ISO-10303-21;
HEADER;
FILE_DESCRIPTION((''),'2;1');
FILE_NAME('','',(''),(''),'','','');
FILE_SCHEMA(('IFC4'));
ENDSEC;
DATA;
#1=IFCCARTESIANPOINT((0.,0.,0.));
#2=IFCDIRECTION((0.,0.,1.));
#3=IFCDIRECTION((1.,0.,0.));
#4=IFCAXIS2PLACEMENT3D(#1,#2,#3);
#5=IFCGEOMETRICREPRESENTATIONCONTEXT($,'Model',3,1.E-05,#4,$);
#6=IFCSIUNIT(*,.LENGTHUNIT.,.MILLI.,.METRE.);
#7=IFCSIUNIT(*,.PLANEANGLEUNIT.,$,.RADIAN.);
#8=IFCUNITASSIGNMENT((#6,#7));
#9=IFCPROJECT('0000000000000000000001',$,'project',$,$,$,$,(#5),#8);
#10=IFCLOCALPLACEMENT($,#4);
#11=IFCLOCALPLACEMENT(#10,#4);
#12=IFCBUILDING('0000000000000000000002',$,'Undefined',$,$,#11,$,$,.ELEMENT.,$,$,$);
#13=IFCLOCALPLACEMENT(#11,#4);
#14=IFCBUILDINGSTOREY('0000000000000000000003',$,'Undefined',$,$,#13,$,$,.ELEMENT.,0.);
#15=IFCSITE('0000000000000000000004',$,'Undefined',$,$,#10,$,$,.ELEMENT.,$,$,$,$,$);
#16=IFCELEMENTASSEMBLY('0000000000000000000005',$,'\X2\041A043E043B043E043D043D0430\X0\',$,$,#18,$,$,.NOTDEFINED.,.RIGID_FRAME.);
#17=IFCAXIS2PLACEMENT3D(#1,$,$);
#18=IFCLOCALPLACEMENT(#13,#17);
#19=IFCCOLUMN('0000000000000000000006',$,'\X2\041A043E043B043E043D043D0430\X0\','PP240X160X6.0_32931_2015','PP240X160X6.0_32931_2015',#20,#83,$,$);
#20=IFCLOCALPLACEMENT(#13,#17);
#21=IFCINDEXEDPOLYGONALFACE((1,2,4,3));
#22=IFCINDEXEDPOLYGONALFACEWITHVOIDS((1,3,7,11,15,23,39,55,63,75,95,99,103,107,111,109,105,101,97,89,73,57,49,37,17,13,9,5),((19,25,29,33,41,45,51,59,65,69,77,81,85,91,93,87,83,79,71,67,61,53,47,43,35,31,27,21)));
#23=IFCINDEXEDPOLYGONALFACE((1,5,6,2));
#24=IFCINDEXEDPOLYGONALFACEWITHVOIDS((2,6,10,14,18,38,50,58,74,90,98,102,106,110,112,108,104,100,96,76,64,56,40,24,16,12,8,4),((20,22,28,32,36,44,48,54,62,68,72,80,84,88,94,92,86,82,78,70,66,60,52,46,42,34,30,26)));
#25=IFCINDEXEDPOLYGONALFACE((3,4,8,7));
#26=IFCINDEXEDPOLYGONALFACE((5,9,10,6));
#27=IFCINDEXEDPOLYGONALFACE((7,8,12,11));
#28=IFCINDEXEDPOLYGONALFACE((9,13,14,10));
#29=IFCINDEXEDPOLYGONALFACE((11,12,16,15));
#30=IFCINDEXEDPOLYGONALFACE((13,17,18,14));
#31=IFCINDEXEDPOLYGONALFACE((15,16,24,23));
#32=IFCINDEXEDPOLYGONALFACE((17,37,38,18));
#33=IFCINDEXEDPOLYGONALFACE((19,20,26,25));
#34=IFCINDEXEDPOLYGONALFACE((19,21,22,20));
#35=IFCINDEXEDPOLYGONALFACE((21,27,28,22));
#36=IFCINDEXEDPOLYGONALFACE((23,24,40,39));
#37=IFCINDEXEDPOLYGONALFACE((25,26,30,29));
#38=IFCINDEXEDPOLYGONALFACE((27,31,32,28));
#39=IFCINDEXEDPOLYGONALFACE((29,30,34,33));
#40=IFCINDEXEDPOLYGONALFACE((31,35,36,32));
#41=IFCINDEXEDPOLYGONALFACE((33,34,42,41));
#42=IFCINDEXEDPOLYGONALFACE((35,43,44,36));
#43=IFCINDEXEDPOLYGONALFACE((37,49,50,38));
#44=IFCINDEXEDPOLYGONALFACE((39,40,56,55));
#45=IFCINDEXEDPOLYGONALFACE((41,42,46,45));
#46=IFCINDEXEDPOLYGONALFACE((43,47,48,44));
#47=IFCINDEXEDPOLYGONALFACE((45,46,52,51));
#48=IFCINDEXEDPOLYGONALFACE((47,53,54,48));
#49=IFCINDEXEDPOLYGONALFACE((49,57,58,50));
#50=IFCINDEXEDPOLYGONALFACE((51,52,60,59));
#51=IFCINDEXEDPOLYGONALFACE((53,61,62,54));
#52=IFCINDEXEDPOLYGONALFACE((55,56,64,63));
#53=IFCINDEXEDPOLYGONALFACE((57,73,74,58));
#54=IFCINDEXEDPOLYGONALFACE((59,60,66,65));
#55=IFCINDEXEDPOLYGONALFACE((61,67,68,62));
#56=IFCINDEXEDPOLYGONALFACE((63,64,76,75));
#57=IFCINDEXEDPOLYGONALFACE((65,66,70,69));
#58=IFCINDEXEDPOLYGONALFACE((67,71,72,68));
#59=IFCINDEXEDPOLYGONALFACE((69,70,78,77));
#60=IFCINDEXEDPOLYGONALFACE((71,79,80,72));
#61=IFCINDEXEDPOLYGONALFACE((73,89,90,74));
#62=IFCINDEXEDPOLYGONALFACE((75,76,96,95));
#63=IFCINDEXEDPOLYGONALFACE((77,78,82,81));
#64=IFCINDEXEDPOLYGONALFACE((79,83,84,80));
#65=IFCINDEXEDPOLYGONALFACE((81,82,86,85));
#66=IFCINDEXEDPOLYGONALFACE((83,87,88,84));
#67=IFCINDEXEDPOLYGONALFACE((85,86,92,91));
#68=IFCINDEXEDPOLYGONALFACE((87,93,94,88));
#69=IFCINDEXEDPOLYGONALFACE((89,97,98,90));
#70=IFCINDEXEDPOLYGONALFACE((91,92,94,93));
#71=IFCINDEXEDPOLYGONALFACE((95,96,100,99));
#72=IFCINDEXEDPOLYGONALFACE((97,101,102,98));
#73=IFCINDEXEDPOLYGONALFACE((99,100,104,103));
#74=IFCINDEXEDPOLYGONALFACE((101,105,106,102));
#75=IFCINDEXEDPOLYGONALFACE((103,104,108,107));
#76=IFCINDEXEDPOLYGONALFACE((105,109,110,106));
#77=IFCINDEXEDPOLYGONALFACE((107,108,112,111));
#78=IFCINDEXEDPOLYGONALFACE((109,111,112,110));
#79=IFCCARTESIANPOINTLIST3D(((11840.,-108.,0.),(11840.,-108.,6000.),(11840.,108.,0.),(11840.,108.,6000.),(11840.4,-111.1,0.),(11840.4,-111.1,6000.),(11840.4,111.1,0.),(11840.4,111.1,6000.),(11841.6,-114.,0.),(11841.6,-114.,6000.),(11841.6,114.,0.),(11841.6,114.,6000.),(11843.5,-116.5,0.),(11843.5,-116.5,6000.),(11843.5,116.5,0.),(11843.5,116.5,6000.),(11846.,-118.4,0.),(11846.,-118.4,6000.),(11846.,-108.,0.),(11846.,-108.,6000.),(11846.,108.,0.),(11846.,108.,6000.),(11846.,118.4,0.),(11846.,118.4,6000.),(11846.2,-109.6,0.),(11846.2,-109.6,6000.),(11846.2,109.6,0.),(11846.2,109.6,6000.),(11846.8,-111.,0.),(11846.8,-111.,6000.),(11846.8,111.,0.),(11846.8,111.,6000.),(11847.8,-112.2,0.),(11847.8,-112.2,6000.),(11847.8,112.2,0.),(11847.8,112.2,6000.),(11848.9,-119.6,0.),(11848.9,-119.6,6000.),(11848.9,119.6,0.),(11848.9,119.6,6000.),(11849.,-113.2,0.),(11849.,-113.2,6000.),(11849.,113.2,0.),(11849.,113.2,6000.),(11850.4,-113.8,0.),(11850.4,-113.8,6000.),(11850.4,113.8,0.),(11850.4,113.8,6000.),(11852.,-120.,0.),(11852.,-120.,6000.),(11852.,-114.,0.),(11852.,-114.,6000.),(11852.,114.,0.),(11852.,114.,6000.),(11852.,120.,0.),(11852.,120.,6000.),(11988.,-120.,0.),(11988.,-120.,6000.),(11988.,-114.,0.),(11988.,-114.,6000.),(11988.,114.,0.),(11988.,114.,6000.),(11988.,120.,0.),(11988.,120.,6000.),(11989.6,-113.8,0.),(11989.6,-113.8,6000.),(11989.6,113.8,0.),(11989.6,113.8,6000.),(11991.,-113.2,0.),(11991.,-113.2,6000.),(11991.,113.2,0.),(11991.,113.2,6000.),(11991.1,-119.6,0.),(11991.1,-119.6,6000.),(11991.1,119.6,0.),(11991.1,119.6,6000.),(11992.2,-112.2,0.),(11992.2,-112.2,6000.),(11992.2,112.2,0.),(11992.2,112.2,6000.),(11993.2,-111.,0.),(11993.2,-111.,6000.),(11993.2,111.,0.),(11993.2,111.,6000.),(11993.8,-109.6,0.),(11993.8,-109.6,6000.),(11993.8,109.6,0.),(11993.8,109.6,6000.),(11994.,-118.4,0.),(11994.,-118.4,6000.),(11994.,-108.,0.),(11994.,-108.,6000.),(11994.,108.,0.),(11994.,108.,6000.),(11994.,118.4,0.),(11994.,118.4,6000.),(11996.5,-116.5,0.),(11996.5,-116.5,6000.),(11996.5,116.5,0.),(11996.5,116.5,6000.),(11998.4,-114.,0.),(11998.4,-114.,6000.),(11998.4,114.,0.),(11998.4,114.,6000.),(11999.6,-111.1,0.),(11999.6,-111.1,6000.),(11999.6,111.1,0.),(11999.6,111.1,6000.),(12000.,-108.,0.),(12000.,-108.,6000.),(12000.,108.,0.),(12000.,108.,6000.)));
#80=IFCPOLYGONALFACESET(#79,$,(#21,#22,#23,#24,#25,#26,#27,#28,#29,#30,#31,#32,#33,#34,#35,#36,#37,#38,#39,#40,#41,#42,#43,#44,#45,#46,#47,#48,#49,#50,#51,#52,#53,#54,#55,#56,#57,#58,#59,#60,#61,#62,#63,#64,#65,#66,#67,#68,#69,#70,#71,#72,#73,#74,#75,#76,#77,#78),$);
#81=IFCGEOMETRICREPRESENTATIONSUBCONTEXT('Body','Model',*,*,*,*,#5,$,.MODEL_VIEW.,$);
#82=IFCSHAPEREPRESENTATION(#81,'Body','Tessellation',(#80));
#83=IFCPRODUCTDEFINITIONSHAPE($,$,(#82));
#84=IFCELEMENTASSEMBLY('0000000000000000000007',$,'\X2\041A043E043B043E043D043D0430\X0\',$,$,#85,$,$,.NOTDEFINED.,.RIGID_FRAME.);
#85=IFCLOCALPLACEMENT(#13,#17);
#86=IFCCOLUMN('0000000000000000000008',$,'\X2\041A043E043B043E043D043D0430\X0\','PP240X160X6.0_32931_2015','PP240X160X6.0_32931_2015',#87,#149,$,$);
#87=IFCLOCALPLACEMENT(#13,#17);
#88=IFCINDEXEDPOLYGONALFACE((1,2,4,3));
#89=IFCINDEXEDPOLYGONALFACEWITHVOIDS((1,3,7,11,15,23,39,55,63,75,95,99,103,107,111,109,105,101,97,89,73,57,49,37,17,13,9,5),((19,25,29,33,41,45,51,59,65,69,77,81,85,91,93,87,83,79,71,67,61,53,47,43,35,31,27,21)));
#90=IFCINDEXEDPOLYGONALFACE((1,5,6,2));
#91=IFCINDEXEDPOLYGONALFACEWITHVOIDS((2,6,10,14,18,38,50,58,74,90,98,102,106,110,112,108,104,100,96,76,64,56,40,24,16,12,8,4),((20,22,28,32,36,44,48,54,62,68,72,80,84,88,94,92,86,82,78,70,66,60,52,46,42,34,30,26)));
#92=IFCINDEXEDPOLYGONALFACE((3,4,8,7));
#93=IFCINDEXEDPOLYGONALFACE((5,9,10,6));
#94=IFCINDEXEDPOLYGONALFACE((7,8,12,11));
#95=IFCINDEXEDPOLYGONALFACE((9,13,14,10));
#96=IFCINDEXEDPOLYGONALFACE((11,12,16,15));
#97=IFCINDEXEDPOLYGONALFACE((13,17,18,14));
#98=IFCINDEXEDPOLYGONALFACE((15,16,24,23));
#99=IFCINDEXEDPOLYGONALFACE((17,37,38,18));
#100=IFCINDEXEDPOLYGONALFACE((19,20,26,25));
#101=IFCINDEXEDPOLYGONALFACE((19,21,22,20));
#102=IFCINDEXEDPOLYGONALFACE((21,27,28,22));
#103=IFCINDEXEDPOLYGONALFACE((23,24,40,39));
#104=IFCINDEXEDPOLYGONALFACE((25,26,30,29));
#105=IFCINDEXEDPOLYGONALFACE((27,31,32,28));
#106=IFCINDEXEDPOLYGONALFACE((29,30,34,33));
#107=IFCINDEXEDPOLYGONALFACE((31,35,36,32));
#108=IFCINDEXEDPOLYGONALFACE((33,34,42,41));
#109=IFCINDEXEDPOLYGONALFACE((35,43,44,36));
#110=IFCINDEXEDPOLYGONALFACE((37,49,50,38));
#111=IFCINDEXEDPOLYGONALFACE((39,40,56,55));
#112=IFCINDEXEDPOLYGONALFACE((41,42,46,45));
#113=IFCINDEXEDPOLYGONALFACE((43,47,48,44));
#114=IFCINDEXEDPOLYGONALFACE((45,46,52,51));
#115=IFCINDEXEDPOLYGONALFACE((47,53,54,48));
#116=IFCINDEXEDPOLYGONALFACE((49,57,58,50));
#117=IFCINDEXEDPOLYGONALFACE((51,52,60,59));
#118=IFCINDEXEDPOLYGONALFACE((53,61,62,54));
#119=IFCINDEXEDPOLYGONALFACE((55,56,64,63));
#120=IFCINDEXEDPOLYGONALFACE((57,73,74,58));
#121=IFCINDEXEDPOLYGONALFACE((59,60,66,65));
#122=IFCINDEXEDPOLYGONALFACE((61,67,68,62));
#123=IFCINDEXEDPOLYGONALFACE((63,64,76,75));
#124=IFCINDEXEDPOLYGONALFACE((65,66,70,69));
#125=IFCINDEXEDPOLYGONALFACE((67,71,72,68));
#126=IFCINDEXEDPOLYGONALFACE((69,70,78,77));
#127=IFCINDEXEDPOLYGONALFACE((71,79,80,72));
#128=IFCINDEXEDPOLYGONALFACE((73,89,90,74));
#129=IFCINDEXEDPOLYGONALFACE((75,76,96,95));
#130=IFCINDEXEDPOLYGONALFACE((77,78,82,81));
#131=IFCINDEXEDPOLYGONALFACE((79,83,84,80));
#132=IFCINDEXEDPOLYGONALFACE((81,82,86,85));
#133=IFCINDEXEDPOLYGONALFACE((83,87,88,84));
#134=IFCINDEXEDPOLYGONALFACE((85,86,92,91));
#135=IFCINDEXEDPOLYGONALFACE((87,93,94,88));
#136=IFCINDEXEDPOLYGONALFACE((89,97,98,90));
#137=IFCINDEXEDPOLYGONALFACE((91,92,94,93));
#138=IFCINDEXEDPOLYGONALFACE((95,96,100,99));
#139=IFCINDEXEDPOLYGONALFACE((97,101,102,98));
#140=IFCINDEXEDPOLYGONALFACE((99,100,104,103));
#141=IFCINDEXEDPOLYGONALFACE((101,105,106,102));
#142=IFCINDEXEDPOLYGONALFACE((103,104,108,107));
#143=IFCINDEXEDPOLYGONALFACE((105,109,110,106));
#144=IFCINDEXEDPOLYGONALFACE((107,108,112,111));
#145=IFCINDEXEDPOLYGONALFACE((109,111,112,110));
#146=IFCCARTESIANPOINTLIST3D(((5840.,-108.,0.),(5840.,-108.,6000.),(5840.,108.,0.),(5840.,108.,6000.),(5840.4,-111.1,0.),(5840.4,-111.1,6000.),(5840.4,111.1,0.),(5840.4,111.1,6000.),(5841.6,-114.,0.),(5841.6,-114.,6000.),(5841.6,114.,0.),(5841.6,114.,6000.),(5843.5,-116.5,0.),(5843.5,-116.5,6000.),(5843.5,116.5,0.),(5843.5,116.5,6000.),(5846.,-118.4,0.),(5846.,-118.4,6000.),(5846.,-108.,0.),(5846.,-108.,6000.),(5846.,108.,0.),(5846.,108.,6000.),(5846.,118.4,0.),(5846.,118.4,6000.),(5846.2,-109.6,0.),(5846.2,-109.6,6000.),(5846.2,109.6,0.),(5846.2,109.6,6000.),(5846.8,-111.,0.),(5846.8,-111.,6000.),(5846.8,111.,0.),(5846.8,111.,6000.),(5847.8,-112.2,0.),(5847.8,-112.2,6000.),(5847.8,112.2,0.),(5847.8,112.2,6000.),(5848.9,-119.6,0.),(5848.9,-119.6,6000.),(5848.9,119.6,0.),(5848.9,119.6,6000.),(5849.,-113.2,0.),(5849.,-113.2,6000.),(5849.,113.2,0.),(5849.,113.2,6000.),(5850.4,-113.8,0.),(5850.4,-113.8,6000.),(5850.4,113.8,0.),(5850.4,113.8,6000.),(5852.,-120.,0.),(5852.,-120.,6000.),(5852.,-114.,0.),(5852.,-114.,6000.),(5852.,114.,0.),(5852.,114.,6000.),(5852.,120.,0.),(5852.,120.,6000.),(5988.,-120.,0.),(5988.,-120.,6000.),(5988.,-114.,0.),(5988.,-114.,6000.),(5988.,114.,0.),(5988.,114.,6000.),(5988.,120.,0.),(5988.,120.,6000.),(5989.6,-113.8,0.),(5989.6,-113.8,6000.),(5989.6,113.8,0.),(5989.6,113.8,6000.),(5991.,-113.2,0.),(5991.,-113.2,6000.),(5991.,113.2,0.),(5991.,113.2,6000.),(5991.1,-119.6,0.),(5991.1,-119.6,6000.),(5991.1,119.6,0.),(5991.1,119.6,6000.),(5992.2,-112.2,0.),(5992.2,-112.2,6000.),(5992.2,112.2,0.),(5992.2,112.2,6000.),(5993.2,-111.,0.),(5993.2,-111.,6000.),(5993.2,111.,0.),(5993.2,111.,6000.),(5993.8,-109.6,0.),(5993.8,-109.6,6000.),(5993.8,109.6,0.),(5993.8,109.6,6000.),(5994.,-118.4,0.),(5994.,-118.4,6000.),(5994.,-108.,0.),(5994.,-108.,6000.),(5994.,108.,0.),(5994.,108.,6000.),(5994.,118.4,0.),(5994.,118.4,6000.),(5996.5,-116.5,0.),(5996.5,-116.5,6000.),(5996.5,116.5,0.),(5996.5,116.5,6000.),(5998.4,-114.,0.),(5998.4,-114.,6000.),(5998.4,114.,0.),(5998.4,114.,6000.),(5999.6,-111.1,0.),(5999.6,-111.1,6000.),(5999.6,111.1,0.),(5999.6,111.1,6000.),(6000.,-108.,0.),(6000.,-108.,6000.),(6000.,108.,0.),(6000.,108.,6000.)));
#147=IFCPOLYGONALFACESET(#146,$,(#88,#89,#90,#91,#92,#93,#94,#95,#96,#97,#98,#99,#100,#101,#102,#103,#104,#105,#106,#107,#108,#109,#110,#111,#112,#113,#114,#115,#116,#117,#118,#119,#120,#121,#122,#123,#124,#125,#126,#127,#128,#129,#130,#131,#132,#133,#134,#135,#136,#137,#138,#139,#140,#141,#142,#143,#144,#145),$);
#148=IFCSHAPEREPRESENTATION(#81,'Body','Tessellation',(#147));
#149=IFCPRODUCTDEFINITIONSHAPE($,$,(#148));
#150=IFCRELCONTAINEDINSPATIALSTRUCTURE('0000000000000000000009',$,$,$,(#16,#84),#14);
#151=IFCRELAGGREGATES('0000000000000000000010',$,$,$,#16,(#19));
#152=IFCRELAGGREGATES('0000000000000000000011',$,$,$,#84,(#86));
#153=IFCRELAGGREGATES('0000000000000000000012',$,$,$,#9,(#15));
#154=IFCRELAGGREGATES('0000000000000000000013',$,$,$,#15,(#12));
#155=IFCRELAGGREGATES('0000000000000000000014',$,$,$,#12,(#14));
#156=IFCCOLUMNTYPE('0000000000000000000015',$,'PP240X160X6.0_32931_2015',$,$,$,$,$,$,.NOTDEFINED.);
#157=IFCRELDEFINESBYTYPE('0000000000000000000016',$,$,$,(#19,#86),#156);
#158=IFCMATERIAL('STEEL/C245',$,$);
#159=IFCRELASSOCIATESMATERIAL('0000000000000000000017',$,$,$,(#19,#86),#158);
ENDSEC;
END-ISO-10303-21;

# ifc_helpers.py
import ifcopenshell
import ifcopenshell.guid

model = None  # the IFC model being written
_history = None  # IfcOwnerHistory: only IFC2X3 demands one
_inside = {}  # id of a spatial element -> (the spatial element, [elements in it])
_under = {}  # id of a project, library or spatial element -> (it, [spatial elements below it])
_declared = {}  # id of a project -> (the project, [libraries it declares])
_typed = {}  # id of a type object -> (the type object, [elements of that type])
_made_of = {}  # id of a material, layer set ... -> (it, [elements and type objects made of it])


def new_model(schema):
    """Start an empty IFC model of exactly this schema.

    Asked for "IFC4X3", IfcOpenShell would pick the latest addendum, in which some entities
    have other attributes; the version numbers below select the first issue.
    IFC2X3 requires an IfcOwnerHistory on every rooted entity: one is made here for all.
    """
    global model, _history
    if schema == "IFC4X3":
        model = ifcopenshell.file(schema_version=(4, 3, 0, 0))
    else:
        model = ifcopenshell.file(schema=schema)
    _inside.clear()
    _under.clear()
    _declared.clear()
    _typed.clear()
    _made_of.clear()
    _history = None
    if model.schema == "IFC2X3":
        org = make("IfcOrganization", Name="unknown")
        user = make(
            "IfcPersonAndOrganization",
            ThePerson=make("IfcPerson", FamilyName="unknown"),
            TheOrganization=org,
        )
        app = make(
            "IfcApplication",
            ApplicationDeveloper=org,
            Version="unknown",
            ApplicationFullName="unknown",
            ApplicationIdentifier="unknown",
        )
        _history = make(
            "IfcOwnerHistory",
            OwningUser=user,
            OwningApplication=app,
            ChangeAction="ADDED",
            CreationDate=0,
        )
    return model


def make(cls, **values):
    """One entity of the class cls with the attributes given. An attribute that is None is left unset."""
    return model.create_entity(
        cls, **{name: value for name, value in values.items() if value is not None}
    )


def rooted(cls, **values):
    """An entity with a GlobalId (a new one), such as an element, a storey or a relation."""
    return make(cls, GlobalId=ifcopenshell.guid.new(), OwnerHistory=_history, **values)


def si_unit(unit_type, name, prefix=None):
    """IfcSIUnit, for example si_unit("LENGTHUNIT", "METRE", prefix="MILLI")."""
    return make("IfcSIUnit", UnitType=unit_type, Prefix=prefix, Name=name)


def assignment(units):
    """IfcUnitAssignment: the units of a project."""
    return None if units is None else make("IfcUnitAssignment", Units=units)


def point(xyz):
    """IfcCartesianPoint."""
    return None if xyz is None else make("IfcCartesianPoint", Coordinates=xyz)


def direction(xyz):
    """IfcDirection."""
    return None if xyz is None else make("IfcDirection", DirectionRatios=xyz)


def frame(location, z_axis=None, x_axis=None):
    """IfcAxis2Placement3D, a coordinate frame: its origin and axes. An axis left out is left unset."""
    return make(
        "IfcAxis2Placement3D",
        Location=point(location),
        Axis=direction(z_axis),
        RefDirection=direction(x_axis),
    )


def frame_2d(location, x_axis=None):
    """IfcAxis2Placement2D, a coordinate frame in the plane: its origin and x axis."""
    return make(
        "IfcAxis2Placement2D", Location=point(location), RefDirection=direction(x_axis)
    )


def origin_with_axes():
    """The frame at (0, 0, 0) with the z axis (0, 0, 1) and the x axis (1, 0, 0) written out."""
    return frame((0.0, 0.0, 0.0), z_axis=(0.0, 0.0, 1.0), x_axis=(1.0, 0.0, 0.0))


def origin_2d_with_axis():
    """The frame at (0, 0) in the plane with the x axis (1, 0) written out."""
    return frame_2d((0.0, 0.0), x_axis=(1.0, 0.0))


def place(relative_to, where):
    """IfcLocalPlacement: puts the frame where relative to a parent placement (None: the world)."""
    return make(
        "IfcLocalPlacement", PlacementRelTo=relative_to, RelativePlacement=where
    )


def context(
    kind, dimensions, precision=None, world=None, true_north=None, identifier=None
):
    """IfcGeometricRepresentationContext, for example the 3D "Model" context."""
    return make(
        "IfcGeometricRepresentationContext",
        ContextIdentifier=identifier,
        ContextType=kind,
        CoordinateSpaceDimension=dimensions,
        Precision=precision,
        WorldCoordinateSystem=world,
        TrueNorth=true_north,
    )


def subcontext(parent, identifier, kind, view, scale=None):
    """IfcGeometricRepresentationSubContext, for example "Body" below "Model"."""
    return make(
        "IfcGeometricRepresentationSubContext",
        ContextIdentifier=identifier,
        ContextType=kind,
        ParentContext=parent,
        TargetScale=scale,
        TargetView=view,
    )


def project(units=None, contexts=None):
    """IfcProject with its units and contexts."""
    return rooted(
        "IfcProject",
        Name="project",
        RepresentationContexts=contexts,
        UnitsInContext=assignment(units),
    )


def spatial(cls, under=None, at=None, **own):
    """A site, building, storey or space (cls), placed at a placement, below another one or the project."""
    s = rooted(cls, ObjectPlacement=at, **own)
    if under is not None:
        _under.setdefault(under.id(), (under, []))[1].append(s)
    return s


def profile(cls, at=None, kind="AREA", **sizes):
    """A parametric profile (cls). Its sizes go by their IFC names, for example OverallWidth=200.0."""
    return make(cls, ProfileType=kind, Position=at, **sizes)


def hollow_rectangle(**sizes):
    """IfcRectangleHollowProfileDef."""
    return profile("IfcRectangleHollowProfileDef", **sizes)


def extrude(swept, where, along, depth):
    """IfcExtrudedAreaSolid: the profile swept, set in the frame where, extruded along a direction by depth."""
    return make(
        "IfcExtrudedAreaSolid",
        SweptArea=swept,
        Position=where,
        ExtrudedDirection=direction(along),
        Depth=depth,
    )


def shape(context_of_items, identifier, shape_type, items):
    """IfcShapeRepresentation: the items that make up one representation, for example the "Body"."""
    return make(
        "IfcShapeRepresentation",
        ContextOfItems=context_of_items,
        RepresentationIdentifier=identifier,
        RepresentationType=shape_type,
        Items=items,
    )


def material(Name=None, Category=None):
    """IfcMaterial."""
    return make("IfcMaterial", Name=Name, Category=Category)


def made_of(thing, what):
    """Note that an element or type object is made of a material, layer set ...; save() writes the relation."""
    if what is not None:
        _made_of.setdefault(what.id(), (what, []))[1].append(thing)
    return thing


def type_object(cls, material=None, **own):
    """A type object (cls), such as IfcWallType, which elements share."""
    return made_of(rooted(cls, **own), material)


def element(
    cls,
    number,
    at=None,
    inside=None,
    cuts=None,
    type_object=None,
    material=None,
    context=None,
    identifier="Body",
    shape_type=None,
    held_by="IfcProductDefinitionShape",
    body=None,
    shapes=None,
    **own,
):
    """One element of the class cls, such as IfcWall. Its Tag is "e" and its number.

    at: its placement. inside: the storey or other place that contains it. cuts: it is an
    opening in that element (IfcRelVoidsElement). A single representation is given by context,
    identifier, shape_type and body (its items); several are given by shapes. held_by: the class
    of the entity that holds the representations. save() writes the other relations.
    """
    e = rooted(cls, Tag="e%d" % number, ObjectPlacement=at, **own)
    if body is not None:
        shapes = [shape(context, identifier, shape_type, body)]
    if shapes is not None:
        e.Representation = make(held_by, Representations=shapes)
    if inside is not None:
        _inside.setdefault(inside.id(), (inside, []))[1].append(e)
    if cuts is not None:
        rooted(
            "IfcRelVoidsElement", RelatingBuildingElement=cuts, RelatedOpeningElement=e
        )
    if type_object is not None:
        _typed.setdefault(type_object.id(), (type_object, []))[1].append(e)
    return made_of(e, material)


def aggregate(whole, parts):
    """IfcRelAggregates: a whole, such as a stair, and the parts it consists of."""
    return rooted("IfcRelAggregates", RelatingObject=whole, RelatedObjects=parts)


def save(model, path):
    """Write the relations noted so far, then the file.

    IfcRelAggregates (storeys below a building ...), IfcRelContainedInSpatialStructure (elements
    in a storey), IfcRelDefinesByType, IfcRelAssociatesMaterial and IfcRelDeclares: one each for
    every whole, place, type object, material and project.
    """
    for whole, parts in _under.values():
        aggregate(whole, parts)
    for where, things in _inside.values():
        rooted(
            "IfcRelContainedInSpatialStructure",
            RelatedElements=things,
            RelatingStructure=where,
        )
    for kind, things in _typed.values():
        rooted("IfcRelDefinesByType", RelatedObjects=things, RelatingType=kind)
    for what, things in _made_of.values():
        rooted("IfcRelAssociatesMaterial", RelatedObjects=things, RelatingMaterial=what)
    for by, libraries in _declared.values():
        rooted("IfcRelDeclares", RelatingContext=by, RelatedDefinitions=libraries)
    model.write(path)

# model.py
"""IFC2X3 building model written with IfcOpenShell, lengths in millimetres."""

from ifc_helpers import new_model, si_unit, frame, origin_with_axes, origin_2d_with_axis, place, context, subcontext, project, spatial, hollow_rectangle, extrude, material, type_object, element, aggregate, save


model = new_model("IFC2X3")

# Units and contexts
model_context = context("Model", 3, precision=1e-05, world=origin_with_axes())
body_context = subcontext(model_context, "Body", "Model", "MODEL_VIEW")
ifc_project = project(units=[si_unit("LENGTHUNIT", "METRE", prefix="MILLI"), si_unit("PLANEANGLEUNIT", "RADIAN")], contexts=[model_context])

# Site, building, storey
site_placement = place(None, origin_with_axes())
site = spatial("IfcSite", under=ifc_project, at=site_placement, Name="Undefined", CompositionType="ELEMENT")
building_placement = place(site_placement, origin_with_axes())
building = spatial("IfcBuilding", under=site, at=building_placement, Name="Undefined", CompositionType="ELEMENT")
storey_placement = place(building_placement, origin_with_axes())
storey = spatial("IfcBuildingStorey", under=building, at=storey_placement, Name="Undefined", CompositionType="ELEMENT", Elevation=0.0)

# Element assemblies, columns
assembly_1_placement = place(storey_placement, origin_with_axes())
assembly_1 = element("IfcElementAssembly", 1, at=assembly_1_placement, inside=storey, Name="Колонна", AssemblyPlace="NOTDEFINED", PredefinedType="RIGID_FRAME")
ifc_material = material(Name="STEEL/C245")
column_type_1 = type_object("IfcColumnType", Name="PP240X160X6.0_32931_2015", PredefinedType="NOTDEFINED")
column_1_placement = place(assembly_1_placement, frame((11920.0, 0.0, 0.0), z_axis=(0.0, 0.0, 1.0), x_axis=(0.0, 1.0, 0.0)))
column_1 = element("IfcColumn", 2, at=column_1_placement, type_object=column_type_1, material=ifc_material, Name="Колонна", Description="PP240X160X6.0_32931_2015", ObjectType="PP240X160X6.0_32931_2015", context=body_context, shape_type="SweptSolid", body=[
    extrude(hollow_rectangle(XDim=160.0, YDim=240.0, WallThickness=6.0, InnerFilletRadius=6.0, OuterFilletRadius=12.0, at=origin_2d_with_axis()), frame((0.0, 0.0, 6000.0), z_axis=(0.0, 0.0, -1.0), x_axis=(0.0, 1.0, 0.0)), (0.0, 0.0, 1.0), 6000.0),
])
aggregate(assembly_1, [column_1])
assembly_2_placement = place(storey_placement, origin_with_axes())
assembly_2 = element("IfcElementAssembly", 3, at=assembly_2_placement, inside=storey, Name="Колонна", AssemblyPlace="NOTDEFINED", PredefinedType="RIGID_FRAME")
column_2_placement = place(assembly_2_placement, frame((5920.0, 0.0, 0.0), z_axis=(0.0, 0.0, 1.0), x_axis=(0.0, 1.0, 0.0)))
column_2 = element("IfcColumn", 4, at=column_2_placement, type_object=column_type_1, material=ifc_material, Name="Колонна", Description="PP240X160X6.0_32931_2015", ObjectType="PP240X160X6.0_32931_2015", context=body_context, shape_type="SweptSolid", body=[
    extrude(hollow_rectangle(XDim=160.0, YDim=240.0, WallThickness=6.0, InnerFilletRadius=6.0, OuterFilletRadius=12.0, at=origin_2d_with_axis()), frame((0.0, 0.0, 6000.0), z_axis=(0.0, 0.0, -1.0), x_axis=(0.0, 1.0, 0.0)), (0.0, 0.0, 1.0), 6000.0),
])
aggregate(assembly_2, [column_2])

save(model, "model.ifc")
